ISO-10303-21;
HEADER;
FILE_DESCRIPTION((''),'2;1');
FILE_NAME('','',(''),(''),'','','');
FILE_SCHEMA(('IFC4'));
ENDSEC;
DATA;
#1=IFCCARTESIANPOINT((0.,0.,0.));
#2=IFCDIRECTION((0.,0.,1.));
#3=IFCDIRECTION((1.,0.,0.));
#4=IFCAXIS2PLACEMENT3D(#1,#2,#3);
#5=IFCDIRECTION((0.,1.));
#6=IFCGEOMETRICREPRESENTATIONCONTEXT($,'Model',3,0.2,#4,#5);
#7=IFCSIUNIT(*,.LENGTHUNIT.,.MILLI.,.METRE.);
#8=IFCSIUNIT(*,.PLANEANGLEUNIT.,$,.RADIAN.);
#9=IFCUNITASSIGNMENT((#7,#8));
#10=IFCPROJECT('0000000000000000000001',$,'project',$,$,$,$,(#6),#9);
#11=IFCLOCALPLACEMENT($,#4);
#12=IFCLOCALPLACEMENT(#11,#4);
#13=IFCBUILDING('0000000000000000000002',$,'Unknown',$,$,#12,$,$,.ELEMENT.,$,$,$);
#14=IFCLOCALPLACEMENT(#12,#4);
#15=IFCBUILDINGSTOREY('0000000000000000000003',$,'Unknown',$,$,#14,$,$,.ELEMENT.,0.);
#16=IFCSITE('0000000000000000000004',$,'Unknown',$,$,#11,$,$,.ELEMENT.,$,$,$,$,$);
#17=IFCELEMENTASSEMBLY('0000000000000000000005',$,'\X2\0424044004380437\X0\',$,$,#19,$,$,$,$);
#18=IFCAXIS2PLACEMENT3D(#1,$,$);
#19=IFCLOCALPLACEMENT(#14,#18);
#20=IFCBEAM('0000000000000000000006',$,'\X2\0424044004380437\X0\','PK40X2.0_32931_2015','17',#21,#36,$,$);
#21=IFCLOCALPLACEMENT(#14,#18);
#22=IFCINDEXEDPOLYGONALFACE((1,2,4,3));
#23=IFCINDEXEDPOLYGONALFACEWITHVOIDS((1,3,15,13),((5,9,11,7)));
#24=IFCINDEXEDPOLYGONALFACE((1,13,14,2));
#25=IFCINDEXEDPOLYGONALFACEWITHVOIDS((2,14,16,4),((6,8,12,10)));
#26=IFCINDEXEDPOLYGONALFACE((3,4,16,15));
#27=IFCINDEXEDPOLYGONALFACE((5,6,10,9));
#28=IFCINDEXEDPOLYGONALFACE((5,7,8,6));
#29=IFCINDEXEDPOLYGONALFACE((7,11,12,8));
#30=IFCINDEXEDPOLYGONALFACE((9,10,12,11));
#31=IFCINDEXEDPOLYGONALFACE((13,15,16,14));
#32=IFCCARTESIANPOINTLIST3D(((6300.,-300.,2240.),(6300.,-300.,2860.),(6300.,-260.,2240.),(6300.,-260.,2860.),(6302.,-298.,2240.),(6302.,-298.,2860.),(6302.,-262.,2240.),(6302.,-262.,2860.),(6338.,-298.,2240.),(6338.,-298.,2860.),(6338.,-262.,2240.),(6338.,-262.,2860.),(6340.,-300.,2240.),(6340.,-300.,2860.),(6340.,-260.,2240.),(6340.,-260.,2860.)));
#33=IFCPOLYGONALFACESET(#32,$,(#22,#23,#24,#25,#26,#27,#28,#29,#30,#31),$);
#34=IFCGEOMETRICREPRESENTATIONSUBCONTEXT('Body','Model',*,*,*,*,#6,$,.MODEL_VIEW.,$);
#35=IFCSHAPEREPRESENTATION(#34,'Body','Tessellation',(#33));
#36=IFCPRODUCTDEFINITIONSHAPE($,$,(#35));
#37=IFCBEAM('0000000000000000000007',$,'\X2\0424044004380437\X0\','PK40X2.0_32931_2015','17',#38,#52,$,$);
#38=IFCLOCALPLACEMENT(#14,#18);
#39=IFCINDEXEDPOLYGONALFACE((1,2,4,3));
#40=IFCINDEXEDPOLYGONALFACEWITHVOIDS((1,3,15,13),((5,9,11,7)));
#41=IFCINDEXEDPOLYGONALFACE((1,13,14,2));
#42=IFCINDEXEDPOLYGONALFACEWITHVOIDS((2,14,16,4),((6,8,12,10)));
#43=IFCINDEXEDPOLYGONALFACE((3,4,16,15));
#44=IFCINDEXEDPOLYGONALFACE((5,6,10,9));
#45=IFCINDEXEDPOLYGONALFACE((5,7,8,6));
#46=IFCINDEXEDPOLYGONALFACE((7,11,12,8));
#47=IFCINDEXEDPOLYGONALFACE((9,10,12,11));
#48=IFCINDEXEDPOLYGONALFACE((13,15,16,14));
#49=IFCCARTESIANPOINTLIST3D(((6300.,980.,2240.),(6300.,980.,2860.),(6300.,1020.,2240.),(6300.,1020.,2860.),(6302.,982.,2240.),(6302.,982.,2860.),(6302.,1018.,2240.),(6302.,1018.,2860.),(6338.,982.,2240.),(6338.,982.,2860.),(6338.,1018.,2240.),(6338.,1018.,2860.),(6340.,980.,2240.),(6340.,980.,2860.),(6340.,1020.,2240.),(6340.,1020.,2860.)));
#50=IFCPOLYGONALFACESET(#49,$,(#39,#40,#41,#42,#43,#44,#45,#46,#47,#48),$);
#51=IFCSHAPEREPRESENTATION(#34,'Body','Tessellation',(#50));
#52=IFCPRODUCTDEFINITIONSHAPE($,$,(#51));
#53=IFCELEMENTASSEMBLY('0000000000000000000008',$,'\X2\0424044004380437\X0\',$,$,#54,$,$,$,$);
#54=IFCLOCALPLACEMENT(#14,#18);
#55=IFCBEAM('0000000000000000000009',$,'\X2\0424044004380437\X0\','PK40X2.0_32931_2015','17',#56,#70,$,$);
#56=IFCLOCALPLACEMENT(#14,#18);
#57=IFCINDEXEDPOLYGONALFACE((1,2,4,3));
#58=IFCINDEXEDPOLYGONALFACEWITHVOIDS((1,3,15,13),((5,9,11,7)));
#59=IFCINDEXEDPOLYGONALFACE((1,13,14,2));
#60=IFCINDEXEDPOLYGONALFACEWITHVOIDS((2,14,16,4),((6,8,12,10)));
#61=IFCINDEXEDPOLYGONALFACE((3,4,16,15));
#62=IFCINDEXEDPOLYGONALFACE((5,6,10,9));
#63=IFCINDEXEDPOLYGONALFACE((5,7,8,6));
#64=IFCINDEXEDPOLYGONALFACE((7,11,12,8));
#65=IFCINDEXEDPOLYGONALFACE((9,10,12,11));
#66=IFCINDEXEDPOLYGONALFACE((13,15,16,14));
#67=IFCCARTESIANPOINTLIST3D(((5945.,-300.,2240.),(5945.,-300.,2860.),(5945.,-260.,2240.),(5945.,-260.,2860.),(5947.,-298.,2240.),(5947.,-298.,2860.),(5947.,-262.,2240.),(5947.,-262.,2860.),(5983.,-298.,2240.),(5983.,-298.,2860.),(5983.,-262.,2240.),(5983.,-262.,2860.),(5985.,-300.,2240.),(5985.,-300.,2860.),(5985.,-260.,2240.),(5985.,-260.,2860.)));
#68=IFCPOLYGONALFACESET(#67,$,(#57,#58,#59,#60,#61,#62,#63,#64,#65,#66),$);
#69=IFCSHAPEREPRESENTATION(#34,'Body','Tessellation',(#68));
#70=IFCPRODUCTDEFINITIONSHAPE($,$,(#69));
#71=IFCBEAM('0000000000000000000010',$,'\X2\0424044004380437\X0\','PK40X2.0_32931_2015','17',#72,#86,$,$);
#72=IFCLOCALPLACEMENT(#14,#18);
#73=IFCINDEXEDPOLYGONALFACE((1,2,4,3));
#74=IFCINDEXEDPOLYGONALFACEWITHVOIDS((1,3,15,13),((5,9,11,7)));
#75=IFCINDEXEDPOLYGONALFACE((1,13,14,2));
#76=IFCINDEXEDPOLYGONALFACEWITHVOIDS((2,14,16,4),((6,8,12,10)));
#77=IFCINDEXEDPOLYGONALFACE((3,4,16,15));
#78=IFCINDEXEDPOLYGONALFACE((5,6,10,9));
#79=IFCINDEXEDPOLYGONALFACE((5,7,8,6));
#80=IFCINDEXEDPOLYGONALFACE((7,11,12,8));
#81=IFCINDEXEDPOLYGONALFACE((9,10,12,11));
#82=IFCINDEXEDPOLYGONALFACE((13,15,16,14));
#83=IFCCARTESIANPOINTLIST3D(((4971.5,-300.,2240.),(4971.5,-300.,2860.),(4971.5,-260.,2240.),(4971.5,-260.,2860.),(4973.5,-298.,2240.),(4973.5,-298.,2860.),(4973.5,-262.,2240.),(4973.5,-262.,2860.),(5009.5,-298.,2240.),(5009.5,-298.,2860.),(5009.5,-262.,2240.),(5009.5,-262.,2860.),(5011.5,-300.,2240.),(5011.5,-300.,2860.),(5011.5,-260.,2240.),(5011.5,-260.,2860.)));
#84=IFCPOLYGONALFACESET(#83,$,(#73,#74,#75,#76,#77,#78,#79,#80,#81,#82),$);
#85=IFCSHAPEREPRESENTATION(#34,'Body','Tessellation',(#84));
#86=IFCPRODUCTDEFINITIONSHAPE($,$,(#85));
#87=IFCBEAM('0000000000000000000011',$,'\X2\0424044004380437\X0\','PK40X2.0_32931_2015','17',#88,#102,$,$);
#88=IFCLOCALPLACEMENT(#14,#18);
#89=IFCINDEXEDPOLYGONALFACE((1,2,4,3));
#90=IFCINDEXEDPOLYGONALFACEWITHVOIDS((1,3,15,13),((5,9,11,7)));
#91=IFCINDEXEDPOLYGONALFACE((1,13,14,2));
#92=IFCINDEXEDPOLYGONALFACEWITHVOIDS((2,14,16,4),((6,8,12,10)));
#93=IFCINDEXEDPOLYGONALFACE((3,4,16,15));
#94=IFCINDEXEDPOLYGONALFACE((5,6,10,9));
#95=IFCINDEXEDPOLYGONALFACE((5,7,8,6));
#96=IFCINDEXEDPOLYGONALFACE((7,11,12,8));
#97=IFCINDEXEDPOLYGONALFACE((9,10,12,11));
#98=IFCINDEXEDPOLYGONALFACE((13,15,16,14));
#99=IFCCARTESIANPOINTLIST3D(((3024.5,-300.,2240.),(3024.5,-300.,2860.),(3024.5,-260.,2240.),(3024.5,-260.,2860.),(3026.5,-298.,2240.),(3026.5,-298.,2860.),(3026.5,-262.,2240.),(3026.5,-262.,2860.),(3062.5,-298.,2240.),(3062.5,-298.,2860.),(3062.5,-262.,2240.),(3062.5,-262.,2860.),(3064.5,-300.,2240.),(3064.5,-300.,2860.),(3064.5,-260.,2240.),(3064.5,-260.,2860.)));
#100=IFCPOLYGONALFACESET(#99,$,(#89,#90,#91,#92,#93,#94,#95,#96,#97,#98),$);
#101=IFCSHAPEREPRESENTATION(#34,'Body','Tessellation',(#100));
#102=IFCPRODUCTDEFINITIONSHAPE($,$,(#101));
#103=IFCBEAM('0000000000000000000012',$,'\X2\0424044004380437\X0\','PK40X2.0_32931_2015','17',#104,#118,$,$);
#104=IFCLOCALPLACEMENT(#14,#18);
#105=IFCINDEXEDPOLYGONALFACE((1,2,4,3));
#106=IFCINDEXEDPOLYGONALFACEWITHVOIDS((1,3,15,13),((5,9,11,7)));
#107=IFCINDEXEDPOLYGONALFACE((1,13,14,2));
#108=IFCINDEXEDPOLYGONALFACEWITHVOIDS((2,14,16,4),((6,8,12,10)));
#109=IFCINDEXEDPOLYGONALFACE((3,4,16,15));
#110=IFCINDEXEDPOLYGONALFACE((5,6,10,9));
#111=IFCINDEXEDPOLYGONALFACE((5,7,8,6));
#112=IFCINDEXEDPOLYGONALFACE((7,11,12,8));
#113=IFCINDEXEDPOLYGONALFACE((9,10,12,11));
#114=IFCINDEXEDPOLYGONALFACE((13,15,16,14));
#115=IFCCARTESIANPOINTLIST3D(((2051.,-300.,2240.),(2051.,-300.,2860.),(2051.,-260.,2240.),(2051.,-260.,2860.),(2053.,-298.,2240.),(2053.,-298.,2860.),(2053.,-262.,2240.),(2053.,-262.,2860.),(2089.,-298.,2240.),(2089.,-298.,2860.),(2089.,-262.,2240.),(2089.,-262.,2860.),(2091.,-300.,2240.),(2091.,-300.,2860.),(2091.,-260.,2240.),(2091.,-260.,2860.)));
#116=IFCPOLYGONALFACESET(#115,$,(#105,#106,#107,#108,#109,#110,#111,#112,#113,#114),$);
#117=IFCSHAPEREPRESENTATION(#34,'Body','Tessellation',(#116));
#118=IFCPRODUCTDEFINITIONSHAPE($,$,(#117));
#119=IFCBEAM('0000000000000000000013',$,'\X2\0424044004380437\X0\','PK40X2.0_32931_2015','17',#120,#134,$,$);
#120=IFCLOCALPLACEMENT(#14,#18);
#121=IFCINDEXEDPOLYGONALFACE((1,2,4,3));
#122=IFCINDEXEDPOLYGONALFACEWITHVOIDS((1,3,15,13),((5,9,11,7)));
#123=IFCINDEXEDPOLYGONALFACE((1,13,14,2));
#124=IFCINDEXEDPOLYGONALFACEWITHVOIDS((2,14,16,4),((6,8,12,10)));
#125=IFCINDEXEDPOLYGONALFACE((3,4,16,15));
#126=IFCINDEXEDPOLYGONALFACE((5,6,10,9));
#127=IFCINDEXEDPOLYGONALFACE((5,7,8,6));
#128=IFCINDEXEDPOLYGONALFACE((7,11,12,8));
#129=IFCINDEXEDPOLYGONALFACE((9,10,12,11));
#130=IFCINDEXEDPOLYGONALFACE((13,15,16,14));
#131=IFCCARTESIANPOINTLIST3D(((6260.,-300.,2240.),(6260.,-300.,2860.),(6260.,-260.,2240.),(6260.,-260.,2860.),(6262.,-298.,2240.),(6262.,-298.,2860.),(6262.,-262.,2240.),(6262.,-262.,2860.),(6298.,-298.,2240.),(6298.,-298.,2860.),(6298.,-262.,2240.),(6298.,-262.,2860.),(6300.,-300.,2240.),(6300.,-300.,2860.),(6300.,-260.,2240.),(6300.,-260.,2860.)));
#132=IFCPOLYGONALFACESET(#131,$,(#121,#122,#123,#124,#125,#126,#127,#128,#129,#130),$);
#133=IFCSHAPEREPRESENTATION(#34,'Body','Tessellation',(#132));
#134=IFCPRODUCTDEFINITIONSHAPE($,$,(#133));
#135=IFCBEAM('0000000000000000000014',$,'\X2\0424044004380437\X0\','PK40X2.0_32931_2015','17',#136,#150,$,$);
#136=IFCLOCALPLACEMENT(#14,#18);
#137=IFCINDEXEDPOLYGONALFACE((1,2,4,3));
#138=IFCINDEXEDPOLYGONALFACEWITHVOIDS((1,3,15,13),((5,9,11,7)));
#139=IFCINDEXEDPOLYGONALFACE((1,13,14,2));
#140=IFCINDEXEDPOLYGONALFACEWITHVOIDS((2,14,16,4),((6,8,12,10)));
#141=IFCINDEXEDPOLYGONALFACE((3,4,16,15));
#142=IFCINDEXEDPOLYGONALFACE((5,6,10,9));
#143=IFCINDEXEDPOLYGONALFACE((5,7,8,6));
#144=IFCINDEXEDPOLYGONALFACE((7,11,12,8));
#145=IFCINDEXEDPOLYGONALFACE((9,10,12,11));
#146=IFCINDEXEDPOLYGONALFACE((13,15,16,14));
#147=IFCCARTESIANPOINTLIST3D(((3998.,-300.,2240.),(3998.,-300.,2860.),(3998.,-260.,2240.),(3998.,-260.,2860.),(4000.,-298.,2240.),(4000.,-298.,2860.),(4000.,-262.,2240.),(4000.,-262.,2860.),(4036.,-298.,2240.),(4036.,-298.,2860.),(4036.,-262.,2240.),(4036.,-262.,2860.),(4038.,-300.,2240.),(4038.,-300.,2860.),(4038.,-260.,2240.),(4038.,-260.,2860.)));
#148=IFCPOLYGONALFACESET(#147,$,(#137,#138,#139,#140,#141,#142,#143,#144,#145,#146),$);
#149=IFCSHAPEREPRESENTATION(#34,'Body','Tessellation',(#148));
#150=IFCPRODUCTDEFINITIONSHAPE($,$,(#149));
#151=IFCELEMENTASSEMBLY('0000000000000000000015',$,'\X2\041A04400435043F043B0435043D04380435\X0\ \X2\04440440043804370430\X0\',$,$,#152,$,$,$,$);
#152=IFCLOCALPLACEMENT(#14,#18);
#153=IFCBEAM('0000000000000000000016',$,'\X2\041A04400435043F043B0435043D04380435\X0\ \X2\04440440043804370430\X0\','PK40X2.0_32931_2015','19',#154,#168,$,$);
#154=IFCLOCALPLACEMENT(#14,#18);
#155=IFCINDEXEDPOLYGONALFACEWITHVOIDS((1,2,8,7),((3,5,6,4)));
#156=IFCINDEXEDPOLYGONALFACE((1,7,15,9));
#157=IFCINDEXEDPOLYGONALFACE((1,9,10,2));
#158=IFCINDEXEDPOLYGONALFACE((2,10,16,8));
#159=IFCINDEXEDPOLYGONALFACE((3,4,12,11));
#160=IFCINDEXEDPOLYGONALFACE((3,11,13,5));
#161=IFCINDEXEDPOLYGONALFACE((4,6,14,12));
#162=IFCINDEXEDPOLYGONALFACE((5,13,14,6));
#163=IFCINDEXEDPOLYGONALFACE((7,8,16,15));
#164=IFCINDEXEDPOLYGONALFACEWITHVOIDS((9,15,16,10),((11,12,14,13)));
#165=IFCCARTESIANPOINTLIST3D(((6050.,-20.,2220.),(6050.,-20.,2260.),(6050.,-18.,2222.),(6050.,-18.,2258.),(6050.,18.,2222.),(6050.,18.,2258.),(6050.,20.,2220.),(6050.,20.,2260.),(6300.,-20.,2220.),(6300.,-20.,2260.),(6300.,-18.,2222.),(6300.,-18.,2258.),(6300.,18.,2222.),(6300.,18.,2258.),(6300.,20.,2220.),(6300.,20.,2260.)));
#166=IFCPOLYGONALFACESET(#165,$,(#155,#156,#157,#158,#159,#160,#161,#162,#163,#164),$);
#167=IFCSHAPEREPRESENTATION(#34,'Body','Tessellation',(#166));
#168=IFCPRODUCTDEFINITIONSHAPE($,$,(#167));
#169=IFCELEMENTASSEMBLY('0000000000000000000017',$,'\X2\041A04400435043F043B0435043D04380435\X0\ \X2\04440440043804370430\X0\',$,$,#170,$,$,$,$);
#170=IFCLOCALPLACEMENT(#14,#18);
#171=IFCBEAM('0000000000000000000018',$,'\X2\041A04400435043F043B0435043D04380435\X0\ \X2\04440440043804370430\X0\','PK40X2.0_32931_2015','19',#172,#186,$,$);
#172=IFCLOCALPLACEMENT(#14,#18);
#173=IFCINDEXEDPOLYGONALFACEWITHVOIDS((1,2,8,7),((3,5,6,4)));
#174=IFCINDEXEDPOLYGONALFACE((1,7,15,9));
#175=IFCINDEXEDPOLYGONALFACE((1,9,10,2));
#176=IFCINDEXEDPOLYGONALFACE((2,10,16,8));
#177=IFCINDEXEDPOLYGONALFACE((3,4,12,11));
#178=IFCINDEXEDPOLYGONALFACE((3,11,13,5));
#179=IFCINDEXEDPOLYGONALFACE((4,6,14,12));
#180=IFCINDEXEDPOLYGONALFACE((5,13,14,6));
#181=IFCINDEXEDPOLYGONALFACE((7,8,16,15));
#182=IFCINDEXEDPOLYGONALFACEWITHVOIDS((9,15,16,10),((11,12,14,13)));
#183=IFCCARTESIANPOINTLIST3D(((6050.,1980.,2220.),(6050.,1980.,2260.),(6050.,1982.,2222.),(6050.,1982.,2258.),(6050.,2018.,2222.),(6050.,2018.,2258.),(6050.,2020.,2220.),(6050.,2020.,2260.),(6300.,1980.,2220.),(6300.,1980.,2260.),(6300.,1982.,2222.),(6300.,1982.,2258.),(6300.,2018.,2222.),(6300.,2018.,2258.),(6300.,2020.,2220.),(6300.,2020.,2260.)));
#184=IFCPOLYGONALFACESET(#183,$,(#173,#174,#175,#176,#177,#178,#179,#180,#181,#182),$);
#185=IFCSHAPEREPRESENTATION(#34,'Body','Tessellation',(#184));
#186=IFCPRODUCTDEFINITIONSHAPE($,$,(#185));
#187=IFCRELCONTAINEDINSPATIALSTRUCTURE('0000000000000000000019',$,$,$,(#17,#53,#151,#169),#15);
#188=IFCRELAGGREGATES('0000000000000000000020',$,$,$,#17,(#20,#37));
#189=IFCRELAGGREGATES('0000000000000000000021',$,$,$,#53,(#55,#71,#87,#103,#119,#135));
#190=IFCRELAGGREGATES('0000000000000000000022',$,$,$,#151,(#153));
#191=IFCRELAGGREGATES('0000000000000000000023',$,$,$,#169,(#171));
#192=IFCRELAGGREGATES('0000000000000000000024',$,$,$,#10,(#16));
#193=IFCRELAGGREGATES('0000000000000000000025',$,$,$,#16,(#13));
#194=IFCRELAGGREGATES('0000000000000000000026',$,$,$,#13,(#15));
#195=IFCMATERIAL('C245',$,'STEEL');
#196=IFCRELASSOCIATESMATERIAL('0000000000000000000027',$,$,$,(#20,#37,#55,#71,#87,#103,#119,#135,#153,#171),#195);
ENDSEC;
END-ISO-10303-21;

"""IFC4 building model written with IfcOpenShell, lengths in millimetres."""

from ifc_helpers import new_model, si_unit, direction, frame, origin_with_axes, place, context, subcontext, project, spatial, line, indexed_curve, outline, extrude, material, element, aggregate, save


model = new_model("IFC4")

# Units and contexts
model_context = context("Model", 3, precision=0.2, world=origin_with_axes(), true_north=direction((0.0, 1.0)))
body_context = subcontext(model_context, "Body", "Model", "MODEL_VIEW")
ifc_project = project(units=[si_unit("LENGTHUNIT", "METRE", prefix="MILLI"), si_unit("PLANEANGLEUNIT", "RADIAN")], contexts=[model_context])

# Site, building, storey
site_placement = place(None, origin_with_axes())
site = spatial("IfcSite", under=ifc_project, at=site_placement, Name="Unknown", CompositionType="ELEMENT")
building_placement = place(site_placement, origin_with_axes())
building = spatial("IfcBuilding", under=site, at=building_placement, Name="Unknown", CompositionType="ELEMENT")
storey_placement = place(building_placement, origin_with_axes())
storey = spatial("IfcBuildingStorey", under=building, at=storey_placement, Name="Unknown", CompositionType="ELEMENT", Elevation=0.0)

# Shared definitions
ifc_material_1 = material(Name="C245", Category="STEEL")

# Element assembly, beams
assembly_1_placement = place(storey_placement, frame((6320.0, -300.0, 2880.0), z_axis=(1.0, 0.0, 0.0), x_axis=(0.0, 1.0, 0.0)))
assembly_1 = element("IfcElementAssembly", 1, at=assembly_1_placement, inside=storey, Name="Фриз")
beam_1_placement = place(assembly_1_placement, frame((20.0, -20.0, 0.0), z_axis=(1.0, 0.0, 0.0), x_axis=(0.0, -1.0, 0.0)))
beam_1 = element("IfcBeam", 2, at=beam_1_placement, material=ifc_material_1, Name="Фриз", Description="PK40X2.0_32931_2015", ObjectType="17", context=body_context, shape_type="SolidModel", body=[
    extrude(outline(indexed_curve([(-20.0, -20.0), (20.0, -20.0), (20.0, 20.0), (-20.0, 20.0)], segments=[line(1, 2, 3, 4, 1)]), holes=[indexed_curve([(-18.0, -18.0), (-18.0, 18.0), (18.0, 18.0), (18.0, -18.0)], segments=[line(1, 2, 3, 4, 1)])]), frame((0.0, 0.0, 0.0), z_axis=(-1.0, 0.0, 0.0), x_axis=(0.0, 0.0, 1.0)), (0.0, 0.0, -1.0), 620.0),
])
beam_2_placement = place(assembly_1_placement, frame((1300.0, -20.0, 0.0), z_axis=(1.0, 0.0, 0.0), x_axis=(0.0, -1.0, 0.0)))
beam_2 = element("IfcBeam", 3, at=beam_2_placement, material=ifc_material_1, Name="Фриз", Description="PK40X2.0_32931_2015", ObjectType="17", context=body_context, shape_type="SolidModel", body=[
    extrude(outline(indexed_curve([(-20.0, -20.0), (20.0, -20.0), (20.0, 20.0), (-20.0, 20.0)], segments=[line(1, 2, 3, 4, 1)]), holes=[indexed_curve([(-18.0, -18.0), (-18.0, 18.0), (18.0, 18.0), (18.0, -18.0)], segments=[line(1, 2, 3, 4, 1)])]), frame((0.0, 0.0, 0.0), z_axis=(-1.0, 0.0, 0.0), x_axis=(0.0, 0.0, 1.0)), (0.0, 0.0, -1.0), 620.0),
])
aggregate(assembly_1, [beam_1, beam_2])

# Element assembly, beams
assembly_2_placement = place(storey_placement, frame((-300.0, -280.0, 2880.0), z_axis=(0.0, -1.0, 0.0), x_axis=(1.0, 0.0, 0.0)))
assembly_2 = element("IfcElementAssembly", 4, at=assembly_2_placement, inside=storey, Name="Фриз")
beam_3_placement = place(assembly_2_placement, frame((6265.0, -20.0, 0.0), z_axis=(0.0, 0.0, 1.0), x_axis=(0.0, -1.0, 0.0)))
beam_3 = element("IfcBeam", 5, at=beam_3_placement, material=ifc_material_1, Name="Фриз", Description="PK40X2.0_32931_2015", ObjectType="17", context=body_context, shape_type="SolidModel", body=[
    extrude(outline(indexed_curve([(-20.0, -20.0), (20.0, -20.0), (20.0, 20.0), (-20.0, 20.0)], segments=[line(1, 2, 3, 4, 1)]), holes=[indexed_curve([(-18.0, -18.0), (-18.0, 18.0), (18.0, 18.0), (18.0, -18.0)], segments=[line(1, 2, 3, 4, 1)])]), frame((0.0, 0.0, 0.0), z_axis=(-1.0, 0.0, 0.0), x_axis=(0.0, 0.0, 1.0)), (0.0, 0.0, -1.0), 620.0),
])
beam_4_placement = place(assembly_2_placement, frame((5291.5, -20.0, 0.0), z_axis=(0.0, 0.0, 1.0), x_axis=(0.0, -1.0, 0.0)))
beam_4 = element("IfcBeam", 6, at=beam_4_placement, material=ifc_material_1, Name="Фриз", Description="PK40X2.0_32931_2015", ObjectType="17", context=body_context, shape_type="SolidModel", body=[
    extrude(outline(indexed_curve([(-20.0, -20.0), (20.0, -20.0), (20.0, 20.0), (-20.0, 20.0)], segments=[line(1, 2, 3, 4, 1)]), holes=[indexed_curve([(-18.0, -18.0), (-18.0, 18.0), (18.0, 18.0), (18.0, -18.0)], segments=[line(1, 2, 3, 4, 1)])]), frame((0.0, 0.0, 0.0), z_axis=(-1.0, 0.0, 0.0), x_axis=(0.0, 0.0, 1.0)), (0.0, 0.0, -1.0), 620.0),
])
beam_5_placement = place(assembly_2_placement, frame((3344.5, -20.0, 0.0), z_axis=(0.0, 0.0, 1.0), x_axis=(0.0, -1.0, 0.0)))
beam_5 = element("IfcBeam", 7, at=beam_5_placement, material=ifc_material_1, Name="Фриз", Description="PK40X2.0_32931_2015", ObjectType="17", context=body_context, shape_type="SolidModel", body=[
    extrude(outline(indexed_curve([(-20.0, -20.0), (20.0, -20.0), (20.0, 20.0), (-20.0, 20.0)], segments=[line(1, 2, 3, 4, 1)]), holes=[indexed_curve([(-18.0, -18.0), (-18.0, 18.0), (18.0, 18.0), (18.0, -18.0)], segments=[line(1, 2, 3, 4, 1)])]), frame((0.0, 0.0, 0.0), z_axis=(-1.0, 0.0, 0.0), x_axis=(0.0, 0.0, 1.0)), (0.0, 0.0, -1.0), 620.0),
])
beam_6_placement = place(assembly_2_placement, frame((2371.0, -20.0, 0.0), z_axis=(0.0, 0.0, 1.0), x_axis=(0.0, -1.0, 0.0)))
beam_6 = element("IfcBeam", 8, at=beam_6_placement, material=ifc_material_1, Name="Фриз", Description="PK40X2.0_32931_2015", ObjectType="17", context=body_context, shape_type="SolidModel", body=[
    extrude(outline(indexed_curve([(-20.0, -20.0), (20.0, -20.0), (20.0, 20.0), (-20.0, 20.0)], segments=[line(1, 2, 3, 4, 1)]), holes=[indexed_curve([(-18.0, -18.0), (-18.0, 18.0), (18.0, 18.0), (18.0, -18.0)], segments=[line(1, 2, 3, 4, 1)])]), frame((0.0, 0.0, 0.0), z_axis=(-1.0, 0.0, 0.0), x_axis=(0.0, 0.0, 1.0)), (0.0, 0.0, -1.0), 620.0),
])
beam_7_placement = place(assembly_2_placement, frame((6580.0, -20.0, 0.0), z_axis=(0.0, 0.0, 1.0), x_axis=(0.0, -1.0, 0.0)))
beam_7 = element("IfcBeam", 9, at=beam_7_placement, material=ifc_material_1, Name="Фриз", Description="PK40X2.0_32931_2015", ObjectType="17", context=body_context, shape_type="SolidModel", body=[
    extrude(outline(indexed_curve([(-20.0, -20.0), (20.0, -20.0), (20.0, 20.0), (-20.0, 20.0)], segments=[line(1, 2, 3, 4, 1)]), holes=[indexed_curve([(-18.0, -18.0), (-18.0, 18.0), (18.0, 18.0), (18.0, -18.0)], segments=[line(1, 2, 3, 4, 1)])]), frame((0.0, 0.0, 0.0), z_axis=(-1.0, 0.0, 0.0), x_axis=(0.0, 0.0, 1.0)), (0.0, 0.0, -1.0), 620.0),
])
beam_8_placement = place(assembly_2_placement, frame((4318.0, -20.0, 0.0), z_axis=(0.0, 0.0, 1.0), x_axis=(0.0, -1.0, 0.0)))
beam_8 = element("IfcBeam", 10, at=beam_8_placement, material=ifc_material_1, Name="Фриз", Description="PK40X2.0_32931_2015", ObjectType="17", context=body_context, shape_type="SolidModel", body=[
    extrude(outline(indexed_curve([(-20.0, -20.0), (20.0, -20.0), (20.0, 20.0), (-20.0, 20.0)], segments=[line(1, 2, 3, 4, 1)]), holes=[indexed_curve([(-18.0, -18.0), (-18.0, 18.0), (18.0, 18.0), (18.0, -18.0)], segments=[line(1, 2, 3, 4, 1)])]), frame((0.0, 0.0, 0.0), z_axis=(-1.0, 0.0, 0.0), x_axis=(0.0, 0.0, 1.0)), (0.0, 0.0, -1.0), 620.0),
])
aggregate(assembly_2, [beam_3, beam_4, beam_5, beam_6, beam_7, beam_8])

# Element assemblies, beams
assembly_3_placement = place(storey_placement, frame((6300.0, 0.0, 2240.0), z_axis=(0.0, -1.0, 0.0), x_axis=(-1.0, 0.0, 0.0)))
assembly_3 = element("IfcElementAssembly", 11, at=assembly_3_placement, inside=storey, Name="Крепление фриза")
beam_9_placement = place(assembly_3_placement, origin_with_axes())
beam_9 = element("IfcBeam", 12, at=beam_9_placement, material=ifc_material_1, Name="Крепление фриза", Description="PK40X2.0_32931_2015", ObjectType="19", context=body_context, shape_type="SolidModel", body=[
    extrude(outline(indexed_curve([(-20.0, -20.0), (20.0, -20.0), (20.0, 20.0), (-20.0, 20.0)], segments=[line(1, 2, 3, 4, 1)]), holes=[indexed_curve([(-18.0, -18.0), (-18.0, 18.0), (18.0, 18.0), (18.0, -18.0)], segments=[line(1, 2, 3, 4, 1)])]), frame((0.0, 0.0, 0.0), z_axis=(-1.0, 0.0, 0.0), x_axis=(0.0, 0.0, 1.0)), (0.0, 0.0, -1.0), 250.0),
])
aggregate(assembly_3, [beam_9])
assembly_4_placement = place(storey_placement, frame((6300.0, 2000.0, 2240.0), z_axis=(0.0, -1.0, 0.0), x_axis=(-1.0, 0.0, 0.0)))
assembly_4 = element("IfcElementAssembly", 13, at=assembly_4_placement, inside=storey, Name="Крепление фриза")
beam_10_placement = place(assembly_4_placement, origin_with_axes())
beam_10 = element("IfcBeam", 14, at=beam_10_placement, material=ifc_material_1, Name="Крепление фриза", Description="PK40X2.0_32931_2015", ObjectType="19", context=body_context, shape_type="SolidModel", body=[
    extrude(outline(indexed_curve([(-20.0, -20.0), (20.0, -20.0), (20.0, 20.0), (-20.0, 20.0)], segments=[line(1, 2, 3, 4, 1)]), holes=[indexed_curve([(-18.0, -18.0), (-18.0, 18.0), (18.0, 18.0), (18.0, -18.0)], segments=[line(1, 2, 3, 4, 1)])]), frame((0.0, 0.0, 0.0), z_axis=(-1.0, 0.0, 0.0), x_axis=(0.0, 0.0, 1.0)), (0.0, 0.0, -1.0), 250.0),
])
aggregate(assembly_4, [beam_10])

save(model, "model.ifc")
